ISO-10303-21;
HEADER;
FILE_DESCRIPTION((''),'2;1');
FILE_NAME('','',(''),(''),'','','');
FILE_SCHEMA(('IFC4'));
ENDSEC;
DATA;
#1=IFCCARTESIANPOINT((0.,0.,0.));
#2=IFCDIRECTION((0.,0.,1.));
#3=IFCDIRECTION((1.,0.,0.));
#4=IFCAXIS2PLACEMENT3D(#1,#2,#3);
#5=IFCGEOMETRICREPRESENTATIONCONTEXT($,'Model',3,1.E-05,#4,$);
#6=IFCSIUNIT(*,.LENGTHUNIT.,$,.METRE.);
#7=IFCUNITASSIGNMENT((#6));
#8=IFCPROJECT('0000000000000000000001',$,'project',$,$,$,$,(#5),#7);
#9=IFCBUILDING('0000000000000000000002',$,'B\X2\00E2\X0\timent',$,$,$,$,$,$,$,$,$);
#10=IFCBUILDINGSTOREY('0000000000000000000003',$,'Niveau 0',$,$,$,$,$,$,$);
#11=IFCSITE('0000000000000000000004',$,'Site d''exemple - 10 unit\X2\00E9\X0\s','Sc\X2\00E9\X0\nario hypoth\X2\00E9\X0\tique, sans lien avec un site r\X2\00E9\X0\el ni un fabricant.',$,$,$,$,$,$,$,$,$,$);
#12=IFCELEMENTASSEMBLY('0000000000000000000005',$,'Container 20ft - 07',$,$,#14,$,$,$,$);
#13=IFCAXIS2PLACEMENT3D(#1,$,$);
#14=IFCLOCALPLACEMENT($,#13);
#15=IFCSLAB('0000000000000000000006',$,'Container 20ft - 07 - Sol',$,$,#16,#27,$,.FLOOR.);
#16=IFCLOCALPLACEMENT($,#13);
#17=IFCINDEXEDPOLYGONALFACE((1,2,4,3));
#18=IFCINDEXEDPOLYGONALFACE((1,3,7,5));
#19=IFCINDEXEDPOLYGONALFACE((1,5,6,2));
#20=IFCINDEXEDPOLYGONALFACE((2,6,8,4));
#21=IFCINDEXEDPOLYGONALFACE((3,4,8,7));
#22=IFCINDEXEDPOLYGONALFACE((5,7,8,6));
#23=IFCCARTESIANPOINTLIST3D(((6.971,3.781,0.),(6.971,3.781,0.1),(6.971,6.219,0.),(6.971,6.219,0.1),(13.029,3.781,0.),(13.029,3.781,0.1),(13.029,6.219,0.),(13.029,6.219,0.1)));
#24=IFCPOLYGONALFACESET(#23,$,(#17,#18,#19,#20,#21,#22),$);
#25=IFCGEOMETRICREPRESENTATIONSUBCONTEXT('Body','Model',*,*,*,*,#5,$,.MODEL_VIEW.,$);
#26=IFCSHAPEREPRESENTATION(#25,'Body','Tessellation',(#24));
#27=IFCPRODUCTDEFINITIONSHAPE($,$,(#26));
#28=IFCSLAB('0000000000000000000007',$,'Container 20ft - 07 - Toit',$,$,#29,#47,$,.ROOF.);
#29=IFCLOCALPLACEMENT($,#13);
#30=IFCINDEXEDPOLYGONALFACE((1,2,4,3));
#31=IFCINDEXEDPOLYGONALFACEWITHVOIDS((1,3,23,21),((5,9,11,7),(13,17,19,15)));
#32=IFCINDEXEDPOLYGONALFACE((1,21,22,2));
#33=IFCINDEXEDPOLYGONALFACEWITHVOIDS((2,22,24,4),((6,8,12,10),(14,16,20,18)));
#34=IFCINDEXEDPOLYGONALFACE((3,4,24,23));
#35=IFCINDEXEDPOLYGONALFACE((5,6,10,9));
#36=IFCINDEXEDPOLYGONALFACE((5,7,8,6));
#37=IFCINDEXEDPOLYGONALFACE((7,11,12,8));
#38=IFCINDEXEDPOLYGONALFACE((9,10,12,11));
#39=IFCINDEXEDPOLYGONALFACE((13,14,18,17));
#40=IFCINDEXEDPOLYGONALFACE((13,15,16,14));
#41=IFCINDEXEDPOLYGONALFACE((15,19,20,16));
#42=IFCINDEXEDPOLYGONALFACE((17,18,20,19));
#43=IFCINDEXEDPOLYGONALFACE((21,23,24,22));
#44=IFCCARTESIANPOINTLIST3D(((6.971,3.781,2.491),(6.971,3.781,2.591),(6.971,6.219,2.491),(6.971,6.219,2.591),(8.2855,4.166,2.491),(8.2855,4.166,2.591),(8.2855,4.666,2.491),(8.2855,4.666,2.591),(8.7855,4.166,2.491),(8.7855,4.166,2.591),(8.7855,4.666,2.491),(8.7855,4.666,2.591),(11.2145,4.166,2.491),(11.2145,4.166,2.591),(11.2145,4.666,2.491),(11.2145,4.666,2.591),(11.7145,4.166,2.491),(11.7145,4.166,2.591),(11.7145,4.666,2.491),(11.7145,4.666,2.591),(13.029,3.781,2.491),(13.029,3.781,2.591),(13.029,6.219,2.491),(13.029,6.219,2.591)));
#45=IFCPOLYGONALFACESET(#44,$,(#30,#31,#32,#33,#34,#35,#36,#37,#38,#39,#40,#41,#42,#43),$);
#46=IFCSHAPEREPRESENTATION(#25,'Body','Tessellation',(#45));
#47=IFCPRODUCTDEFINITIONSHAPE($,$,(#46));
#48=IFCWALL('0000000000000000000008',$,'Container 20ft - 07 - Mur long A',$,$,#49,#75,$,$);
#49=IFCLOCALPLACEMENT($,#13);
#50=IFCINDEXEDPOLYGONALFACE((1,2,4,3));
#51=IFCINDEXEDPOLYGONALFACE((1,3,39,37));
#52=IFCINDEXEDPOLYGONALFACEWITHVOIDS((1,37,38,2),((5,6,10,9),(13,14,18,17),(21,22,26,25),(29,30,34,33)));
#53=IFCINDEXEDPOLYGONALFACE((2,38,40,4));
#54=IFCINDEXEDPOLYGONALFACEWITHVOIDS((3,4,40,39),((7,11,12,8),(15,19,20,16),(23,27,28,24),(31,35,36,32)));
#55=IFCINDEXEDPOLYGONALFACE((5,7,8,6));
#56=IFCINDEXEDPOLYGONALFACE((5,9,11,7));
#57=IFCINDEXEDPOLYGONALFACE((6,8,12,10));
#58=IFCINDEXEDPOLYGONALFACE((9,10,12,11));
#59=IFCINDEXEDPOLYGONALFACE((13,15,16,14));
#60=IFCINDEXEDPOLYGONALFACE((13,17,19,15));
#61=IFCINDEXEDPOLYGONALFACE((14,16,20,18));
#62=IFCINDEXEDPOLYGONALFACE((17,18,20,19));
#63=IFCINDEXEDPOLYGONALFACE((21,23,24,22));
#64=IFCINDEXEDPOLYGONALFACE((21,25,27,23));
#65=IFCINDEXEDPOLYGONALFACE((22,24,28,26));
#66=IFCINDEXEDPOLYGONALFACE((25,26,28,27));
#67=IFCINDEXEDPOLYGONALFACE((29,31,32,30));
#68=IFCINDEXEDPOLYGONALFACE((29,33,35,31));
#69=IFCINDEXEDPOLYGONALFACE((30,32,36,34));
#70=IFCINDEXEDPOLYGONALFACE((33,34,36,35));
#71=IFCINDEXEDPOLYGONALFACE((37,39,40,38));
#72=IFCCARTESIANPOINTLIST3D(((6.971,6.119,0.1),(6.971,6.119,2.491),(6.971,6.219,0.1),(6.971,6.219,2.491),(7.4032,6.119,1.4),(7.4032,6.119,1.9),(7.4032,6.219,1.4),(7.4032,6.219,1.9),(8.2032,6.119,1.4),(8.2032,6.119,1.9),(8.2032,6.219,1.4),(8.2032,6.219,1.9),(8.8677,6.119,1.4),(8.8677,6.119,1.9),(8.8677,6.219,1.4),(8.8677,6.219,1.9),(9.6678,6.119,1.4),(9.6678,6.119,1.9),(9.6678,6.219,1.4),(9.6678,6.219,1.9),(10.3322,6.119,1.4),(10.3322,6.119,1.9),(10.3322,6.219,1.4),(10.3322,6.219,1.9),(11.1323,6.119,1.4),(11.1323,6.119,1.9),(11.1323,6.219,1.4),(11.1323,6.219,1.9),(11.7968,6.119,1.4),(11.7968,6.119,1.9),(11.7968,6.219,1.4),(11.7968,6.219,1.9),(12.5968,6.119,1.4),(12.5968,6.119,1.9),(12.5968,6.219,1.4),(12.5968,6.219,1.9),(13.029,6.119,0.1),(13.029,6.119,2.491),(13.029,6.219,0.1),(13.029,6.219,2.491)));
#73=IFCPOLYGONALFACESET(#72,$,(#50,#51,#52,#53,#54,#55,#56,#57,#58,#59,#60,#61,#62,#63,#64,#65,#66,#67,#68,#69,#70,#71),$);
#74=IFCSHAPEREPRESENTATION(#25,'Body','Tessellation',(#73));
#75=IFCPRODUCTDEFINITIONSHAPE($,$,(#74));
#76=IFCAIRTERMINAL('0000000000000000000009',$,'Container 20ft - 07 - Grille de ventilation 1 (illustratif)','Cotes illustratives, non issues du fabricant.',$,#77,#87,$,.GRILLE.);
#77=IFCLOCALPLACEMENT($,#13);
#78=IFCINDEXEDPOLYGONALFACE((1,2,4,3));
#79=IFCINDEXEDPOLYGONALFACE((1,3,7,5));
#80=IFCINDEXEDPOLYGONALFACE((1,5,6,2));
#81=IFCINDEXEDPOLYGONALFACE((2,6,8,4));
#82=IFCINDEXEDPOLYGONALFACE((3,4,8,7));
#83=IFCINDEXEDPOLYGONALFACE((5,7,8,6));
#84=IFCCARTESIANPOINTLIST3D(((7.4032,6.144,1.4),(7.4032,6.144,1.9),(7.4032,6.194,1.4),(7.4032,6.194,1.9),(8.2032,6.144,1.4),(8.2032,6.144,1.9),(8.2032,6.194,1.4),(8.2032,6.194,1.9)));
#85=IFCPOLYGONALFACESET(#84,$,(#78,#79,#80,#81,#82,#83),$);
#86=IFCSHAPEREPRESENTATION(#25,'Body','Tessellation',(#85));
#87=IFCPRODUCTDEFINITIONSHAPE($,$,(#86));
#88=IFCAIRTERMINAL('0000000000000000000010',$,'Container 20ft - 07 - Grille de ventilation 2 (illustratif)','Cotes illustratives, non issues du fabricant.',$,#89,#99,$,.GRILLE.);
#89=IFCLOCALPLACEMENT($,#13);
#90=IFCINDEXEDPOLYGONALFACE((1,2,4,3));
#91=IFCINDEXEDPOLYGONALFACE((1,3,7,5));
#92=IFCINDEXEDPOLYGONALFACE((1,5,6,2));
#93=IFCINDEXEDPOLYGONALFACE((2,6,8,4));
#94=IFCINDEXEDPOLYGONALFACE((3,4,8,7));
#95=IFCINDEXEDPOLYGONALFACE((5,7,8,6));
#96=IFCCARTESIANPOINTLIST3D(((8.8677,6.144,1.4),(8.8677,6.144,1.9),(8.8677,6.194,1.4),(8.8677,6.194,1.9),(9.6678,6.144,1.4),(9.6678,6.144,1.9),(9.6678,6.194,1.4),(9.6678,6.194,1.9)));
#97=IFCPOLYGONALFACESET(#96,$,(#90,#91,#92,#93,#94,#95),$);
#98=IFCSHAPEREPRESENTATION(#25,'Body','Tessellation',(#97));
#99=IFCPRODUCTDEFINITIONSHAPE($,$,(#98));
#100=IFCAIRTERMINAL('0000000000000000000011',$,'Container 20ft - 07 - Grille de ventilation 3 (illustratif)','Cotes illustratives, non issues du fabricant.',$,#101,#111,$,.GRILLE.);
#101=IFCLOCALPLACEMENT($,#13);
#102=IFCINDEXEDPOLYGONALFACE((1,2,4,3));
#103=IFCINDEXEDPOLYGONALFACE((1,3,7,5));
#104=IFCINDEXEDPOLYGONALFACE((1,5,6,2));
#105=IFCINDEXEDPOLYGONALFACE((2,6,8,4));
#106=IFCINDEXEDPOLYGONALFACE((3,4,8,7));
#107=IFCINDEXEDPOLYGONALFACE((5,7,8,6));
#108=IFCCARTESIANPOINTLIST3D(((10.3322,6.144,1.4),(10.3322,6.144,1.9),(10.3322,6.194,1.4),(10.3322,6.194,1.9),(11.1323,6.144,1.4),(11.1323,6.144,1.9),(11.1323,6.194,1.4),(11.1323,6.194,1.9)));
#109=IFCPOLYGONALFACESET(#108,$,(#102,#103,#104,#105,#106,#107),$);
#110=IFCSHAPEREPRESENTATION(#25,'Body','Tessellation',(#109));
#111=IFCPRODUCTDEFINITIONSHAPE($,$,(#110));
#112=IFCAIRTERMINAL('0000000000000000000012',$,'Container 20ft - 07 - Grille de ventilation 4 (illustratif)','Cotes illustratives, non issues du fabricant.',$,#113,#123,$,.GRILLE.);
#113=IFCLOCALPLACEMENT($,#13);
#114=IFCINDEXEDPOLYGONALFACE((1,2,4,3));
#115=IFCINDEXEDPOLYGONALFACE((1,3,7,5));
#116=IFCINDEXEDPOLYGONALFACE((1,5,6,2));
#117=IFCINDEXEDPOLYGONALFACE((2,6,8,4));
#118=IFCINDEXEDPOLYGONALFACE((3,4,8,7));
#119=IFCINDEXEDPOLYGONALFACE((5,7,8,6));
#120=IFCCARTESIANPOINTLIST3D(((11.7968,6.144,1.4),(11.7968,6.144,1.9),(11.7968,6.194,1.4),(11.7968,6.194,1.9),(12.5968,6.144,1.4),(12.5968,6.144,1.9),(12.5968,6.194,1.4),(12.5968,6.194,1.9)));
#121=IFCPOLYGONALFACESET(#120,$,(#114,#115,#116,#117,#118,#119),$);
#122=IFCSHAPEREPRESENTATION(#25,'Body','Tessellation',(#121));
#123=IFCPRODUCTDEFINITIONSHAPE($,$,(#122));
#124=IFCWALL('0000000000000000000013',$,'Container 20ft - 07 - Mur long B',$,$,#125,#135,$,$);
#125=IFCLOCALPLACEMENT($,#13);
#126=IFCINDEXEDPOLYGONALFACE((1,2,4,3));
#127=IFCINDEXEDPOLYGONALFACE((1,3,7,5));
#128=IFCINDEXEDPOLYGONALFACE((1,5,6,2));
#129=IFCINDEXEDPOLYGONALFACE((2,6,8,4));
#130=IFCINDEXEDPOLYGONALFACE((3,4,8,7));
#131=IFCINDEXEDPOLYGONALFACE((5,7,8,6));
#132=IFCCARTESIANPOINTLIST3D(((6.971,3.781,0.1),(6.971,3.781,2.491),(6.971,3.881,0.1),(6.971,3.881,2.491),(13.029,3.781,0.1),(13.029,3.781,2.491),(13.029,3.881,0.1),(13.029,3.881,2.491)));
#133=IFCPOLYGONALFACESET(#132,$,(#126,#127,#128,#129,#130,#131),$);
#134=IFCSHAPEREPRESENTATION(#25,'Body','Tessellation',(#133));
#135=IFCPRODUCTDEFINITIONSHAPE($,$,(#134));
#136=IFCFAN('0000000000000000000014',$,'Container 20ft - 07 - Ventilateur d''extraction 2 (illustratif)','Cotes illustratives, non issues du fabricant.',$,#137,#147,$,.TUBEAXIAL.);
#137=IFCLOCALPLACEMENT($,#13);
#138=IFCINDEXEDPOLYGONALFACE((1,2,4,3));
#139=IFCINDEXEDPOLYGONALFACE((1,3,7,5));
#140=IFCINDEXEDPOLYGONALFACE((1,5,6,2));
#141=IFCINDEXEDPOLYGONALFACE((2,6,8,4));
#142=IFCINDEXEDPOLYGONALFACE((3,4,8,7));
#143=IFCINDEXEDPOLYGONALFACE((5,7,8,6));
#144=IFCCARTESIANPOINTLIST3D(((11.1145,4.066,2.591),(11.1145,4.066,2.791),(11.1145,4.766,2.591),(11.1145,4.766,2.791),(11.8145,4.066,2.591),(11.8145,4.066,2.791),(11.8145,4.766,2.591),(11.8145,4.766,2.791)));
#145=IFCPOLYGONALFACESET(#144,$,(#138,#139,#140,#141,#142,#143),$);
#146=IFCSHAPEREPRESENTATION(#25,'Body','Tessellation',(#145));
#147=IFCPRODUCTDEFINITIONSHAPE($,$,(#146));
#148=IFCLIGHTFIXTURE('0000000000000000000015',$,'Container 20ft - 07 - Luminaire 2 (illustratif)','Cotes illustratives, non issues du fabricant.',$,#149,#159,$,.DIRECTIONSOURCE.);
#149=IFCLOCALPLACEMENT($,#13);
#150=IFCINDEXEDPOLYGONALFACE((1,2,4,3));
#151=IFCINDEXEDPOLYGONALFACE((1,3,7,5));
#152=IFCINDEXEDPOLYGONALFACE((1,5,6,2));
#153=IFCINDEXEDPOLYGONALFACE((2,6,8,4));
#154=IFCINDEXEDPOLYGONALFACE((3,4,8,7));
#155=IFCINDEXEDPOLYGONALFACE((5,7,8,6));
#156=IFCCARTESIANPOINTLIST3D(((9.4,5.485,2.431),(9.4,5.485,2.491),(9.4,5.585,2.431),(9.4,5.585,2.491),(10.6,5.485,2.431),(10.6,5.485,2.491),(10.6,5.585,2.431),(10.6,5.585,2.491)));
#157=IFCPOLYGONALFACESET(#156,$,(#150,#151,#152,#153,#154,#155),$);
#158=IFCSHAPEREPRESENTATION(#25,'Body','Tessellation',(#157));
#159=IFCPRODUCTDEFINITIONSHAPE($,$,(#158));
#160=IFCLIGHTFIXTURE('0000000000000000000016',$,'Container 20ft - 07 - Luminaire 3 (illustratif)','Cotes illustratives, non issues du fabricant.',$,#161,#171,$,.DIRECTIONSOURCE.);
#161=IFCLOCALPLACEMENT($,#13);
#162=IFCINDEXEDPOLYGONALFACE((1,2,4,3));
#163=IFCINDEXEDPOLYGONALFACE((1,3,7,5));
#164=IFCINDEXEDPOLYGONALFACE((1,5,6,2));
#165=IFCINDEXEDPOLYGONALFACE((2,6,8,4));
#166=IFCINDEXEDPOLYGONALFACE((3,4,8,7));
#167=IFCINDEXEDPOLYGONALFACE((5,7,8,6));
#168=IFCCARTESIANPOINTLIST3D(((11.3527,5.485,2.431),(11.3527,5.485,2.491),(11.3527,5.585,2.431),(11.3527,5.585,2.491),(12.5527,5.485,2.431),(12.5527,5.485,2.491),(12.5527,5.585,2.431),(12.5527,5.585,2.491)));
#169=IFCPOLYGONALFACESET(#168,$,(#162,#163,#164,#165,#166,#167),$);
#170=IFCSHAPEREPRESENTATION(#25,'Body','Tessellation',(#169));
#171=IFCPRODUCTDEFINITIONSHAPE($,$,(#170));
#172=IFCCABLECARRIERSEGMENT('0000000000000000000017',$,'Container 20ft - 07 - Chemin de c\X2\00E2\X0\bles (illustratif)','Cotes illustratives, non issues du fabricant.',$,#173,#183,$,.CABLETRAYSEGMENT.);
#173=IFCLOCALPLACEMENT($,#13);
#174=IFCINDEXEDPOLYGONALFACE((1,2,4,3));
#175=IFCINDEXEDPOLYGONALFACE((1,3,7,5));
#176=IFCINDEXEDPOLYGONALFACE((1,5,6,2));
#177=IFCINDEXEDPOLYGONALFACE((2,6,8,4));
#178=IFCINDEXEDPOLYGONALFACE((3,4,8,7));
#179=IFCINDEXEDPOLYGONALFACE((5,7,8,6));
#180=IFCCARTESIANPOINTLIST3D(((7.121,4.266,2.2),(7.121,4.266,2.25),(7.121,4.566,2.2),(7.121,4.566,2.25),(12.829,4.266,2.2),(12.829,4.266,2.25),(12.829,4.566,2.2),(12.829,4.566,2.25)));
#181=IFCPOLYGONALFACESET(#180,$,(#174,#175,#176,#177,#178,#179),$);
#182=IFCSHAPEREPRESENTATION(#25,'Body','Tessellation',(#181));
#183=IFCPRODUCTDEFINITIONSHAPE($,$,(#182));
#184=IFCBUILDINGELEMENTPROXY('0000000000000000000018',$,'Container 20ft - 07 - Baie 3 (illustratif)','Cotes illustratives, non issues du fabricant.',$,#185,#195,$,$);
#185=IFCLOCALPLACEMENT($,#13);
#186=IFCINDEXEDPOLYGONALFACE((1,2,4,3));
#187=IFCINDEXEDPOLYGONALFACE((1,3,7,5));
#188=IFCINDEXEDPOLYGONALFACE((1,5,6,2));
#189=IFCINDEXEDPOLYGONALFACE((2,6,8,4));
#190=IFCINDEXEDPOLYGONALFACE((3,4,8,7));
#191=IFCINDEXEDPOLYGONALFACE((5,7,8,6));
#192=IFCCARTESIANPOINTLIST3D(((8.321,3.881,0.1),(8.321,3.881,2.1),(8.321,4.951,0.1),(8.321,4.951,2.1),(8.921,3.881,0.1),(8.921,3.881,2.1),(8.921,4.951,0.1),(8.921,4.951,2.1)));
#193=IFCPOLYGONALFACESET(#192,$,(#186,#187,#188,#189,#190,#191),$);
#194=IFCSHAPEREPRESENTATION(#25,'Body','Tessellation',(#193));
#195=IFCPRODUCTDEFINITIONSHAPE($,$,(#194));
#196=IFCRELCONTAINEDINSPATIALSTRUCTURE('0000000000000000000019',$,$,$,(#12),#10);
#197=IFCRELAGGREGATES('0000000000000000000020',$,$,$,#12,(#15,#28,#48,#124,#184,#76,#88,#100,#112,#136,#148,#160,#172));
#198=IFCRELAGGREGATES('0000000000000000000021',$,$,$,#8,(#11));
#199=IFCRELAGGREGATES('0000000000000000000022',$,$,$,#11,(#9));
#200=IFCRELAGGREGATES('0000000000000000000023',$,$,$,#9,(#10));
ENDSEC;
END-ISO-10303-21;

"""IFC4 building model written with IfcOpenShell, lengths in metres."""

from ifc_helpers import new_model, si_unit, frame, origin_with_axes, place, context, subcontext, project, spatial, rectangle, extrude, element, fill, aggregate, save


model = new_model("IFC4")

# Units and contexts
model_context = context("Model", 3, precision=1e-05, world=origin_with_axes())
body_context = subcontext(model_context, "Body", "Model", "MODEL_VIEW")
ifc_project = project(units=[si_unit("LENGTHUNIT", "METRE")], contexts=[model_context])

# Site, building, storey
site = spatial("IfcSite", under=ifc_project, Name="Site d'exemple - 10 unités", Description="Scénario hypothétique, sans lien avec un site réel ni un fabricant.")
building = spatial("IfcBuilding", under=site, Name="Bâtiment")
storey = spatial("IfcBuildingStorey", under=building, Name="Niveau 0")

# Element assembly, slabs, openings, walls, air terminals, fan, light fixtures, cable carrier segment, building element proxy
assembly = element("IfcElementAssembly", 1, inside=storey, Name="Container 20ft - 07")
slab_1_placement = place(None, frame((10.0, 5.0, 0.0), z_axis=(0.0, 0.0, 1.0), x_axis=(1.0, 0.0, 0.0)))
slab_1 = element("IfcSlab", 2, at=slab_1_placement, Name="Container 20ft - 07 - Sol", PredefinedType="FLOOR", context=body_context, shape_type="SweptSolid", body=[
    extrude(rectangle(XDim=6.058, YDim=2.438), origin_with_axes(), (0.0, 0.0, 1.0), 0.1),
])
slab_2_placement = place(None, frame((10.0, 5.0, 2.491), z_axis=(0.0, 0.0, 1.0), x_axis=(1.0, 0.0, 0.0)))
slab_2 = element("IfcSlab", 3, at=slab_2_placement, Name="Container 20ft - 07 - Toit", PredefinedType="ROOF", context=body_context, shape_type="SweptSolid", body=[
    extrude(rectangle(XDim=6.058, YDim=2.438), origin_with_axes(), (0.0, 0.0, 1.0), 0.1),
])
opening_1_placement = place(None, frame((8.5355, 4.416, 2.441), z_axis=(0.0, 0.0, 1.0), x_axis=(1.0, 0.0, 0.0)))
element("IfcOpeningElement", 4, at=opening_1_placement, cuts=slab_2, PredefinedType="OPENING", context=body_context, shape_type="SweptSolid", body=[
    extrude(rectangle(XDim=0.5, YDim=0.5), origin_with_axes(), (0.0, 0.0, 1.0), 0.2),
])
opening_2_placement = place(None, frame((11.4645, 4.416, 2.441), z_axis=(0.0, 0.0, 1.0), x_axis=(1.0, 0.0, 0.0)))
element("IfcOpeningElement", 5, at=opening_2_placement, cuts=slab_2, PredefinedType="OPENING", context=body_context, shape_type="SweptSolid", body=[
    extrude(rectangle(XDim=0.5, YDim=0.5), origin_with_axes(), (0.0, 0.0, 1.0), 0.2),
])
wall_1_placement = place(None, frame((10.0, 6.169, 0.1), z_axis=(0.0, 0.0, 1.0), x_axis=(1.0, 0.0, 0.0)))
wall_1 = element("IfcWall", 6, at=wall_1_placement, Name="Container 20ft - 07 - Mur long A", context=body_context, shape_type="SweptSolid", body=[
    extrude(rectangle(XDim=6.058, YDim=0.1), origin_with_axes(), (0.0, 0.0, 1.0), 2.391),
])
opening_3_placement = place(None, frame((7.8033, 6.169, 1.4), z_axis=(0.0, 0.0, 1.0), x_axis=(1.0, 0.0, 0.0)))
opening_3 = element("IfcOpeningElement", 7, at=opening_3_placement, cuts=wall_1, PredefinedType="OPENING", context=body_context, shape_type="SweptSolid", body=[
    extrude(rectangle(XDim=0.8, YDim=0.2), origin_with_axes(), (0.0, 0.0, 1.0), 0.5),
])
opening_4_placement = place(None, frame((9.2677, 6.169, 1.4), z_axis=(0.0, 0.0, 1.0), x_axis=(1.0, 0.0, 0.0)))
opening_4 = element("IfcOpeningElement", 8, at=opening_4_placement, cuts=wall_1, PredefinedType="OPENING", context=body_context, shape_type="SweptSolid", body=[
    extrude(rectangle(XDim=0.8, YDim=0.2), origin_with_axes(), (0.0, 0.0, 1.0), 0.5),
])
opening_5_placement = place(None, frame((10.7323, 6.169, 1.4), z_axis=(0.0, 0.0, 1.0), x_axis=(1.0, 0.0, 0.0)))
opening_5 = element("IfcOpeningElement", 9, at=opening_5_placement, cuts=wall_1, PredefinedType="OPENING", context=body_context, shape_type="SweptSolid", body=[
    extrude(rectangle(XDim=0.8, YDim=0.2), origin_with_axes(), (0.0, 0.0, 1.0), 0.5),
])
opening_6_placement = place(None, frame((12.1967, 6.169, 1.4), z_axis=(0.0, 0.0, 1.0), x_axis=(1.0, 0.0, 0.0)))
opening_6 = element("IfcOpeningElement", 10, at=opening_6_placement, cuts=wall_1, PredefinedType="OPENING", context=body_context, shape_type="SweptSolid", body=[
    extrude(rectangle(XDim=0.8, YDim=0.2), origin_with_axes(), (0.0, 0.0, 1.0), 0.5),
])
air_terminal_1_placement = place(None, frame((7.8033, 6.169, 1.4), z_axis=(0.0, 0.0, 1.0), x_axis=(1.0, 0.0, 0.0)))
air_terminal_1 = element("IfcAirTerminal", 11, at=air_terminal_1_placement, Name="Container 20ft - 07 - Grille de ventilation 1 (illustratif)", Description="Cotes illustratives, non issues du fabricant.", PredefinedType="GRILLE", context=body_context, shape_type="SweptSolid", body=[
    extrude(rectangle(XDim=0.8, YDim=0.05), origin_with_axes(), (0.0, 0.0, 1.0), 0.5),
])
fill(opening_3, air_terminal_1)
air_terminal_2_placement = place(None, frame((9.2677, 6.169, 1.4), z_axis=(0.0, 0.0, 1.0), x_axis=(1.0, 0.0, 0.0)))
air_terminal_2 = element("IfcAirTerminal", 12, at=air_terminal_2_placement, Name="Container 20ft - 07 - Grille de ventilation 2 (illustratif)", Description="Cotes illustratives, non issues du fabricant.", PredefinedType="GRILLE", context=body_context, shape_type="SweptSolid", body=[
    extrude(rectangle(XDim=0.8, YDim=0.05), origin_with_axes(), (0.0, 0.0, 1.0), 0.5),
])
fill(opening_4, air_terminal_2)
air_terminal_3_placement = place(None, frame((10.7323, 6.169, 1.4), z_axis=(0.0, 0.0, 1.0), x_axis=(1.0, 0.0, 0.0)))
air_terminal_3 = element("IfcAirTerminal", 13, at=air_terminal_3_placement, Name="Container 20ft - 07 - Grille de ventilation 3 (illustratif)", Description="Cotes illustratives, non issues du fabricant.", PredefinedType="GRILLE", context=body_context, shape_type="SweptSolid", body=[
    extrude(rectangle(XDim=0.8, YDim=0.05), origin_with_axes(), (0.0, 0.0, 1.0), 0.5),
])
fill(opening_5, air_terminal_3)
air_terminal_4_placement = place(None, frame((12.1967, 6.169, 1.4), z_axis=(0.0, 0.0, 1.0), x_axis=(1.0, 0.0, 0.0)))
air_terminal_4 = element("IfcAirTerminal", 14, at=air_terminal_4_placement, Name="Container 20ft - 07 - Grille de ventilation 4 (illustratif)", Description="Cotes illustratives, non issues du fabricant.", PredefinedType="GRILLE", context=body_context, shape_type="SweptSolid", body=[
    extrude(rectangle(XDim=0.8, YDim=0.05), origin_with_axes(), (0.0, 0.0, 1.0), 0.5),
])
fill(opening_6, air_terminal_4)
wall_2_placement = place(None, frame((10.0, 3.831, 0.1), z_axis=(0.0, 0.0, 1.0), x_axis=(1.0, 0.0, 0.0)))
wall_2 = element("IfcWall", 15, at=wall_2_placement, Name="Container 20ft - 07 - Mur long B", context=body_context, shape_type="SweptSolid", body=[
    extrude(rectangle(XDim=6.058, YDim=0.1), origin_with_axes(), (0.0, 0.0, 1.0), 2.391),
])
fan_placement = place(None, frame((11.4645, 4.416, 2.591), z_axis=(0.0, 0.0, 1.0), x_axis=(1.0, 0.0, 0.0)))
fan = element("IfcFan", 16, at=fan_placement, Name="Container 20ft - 07 - Ventilateur d'extraction 2 (illustratif)", Description="Cotes illustratives, non issues du fabricant.", PredefinedType="TUBEAXIAL", context=body_context, shape_type="SweptSolid", body=[
    extrude(rectangle(XDim=0.7, YDim=0.7), origin_with_axes(), (0.0, 0.0, 1.0), 0.2),
])
light_fixture_1_placement = place(None, frame((10.0, 5.535, 2.431), z_axis=(0.0, 0.0, 1.0), x_axis=(1.0, 0.0, 0.0)))
light_fixture_1 = element("IfcLightFixture", 17, at=light_fixture_1_placement, Name="Container 20ft - 07 - Luminaire 2 (illustratif)", Description="Cotes illustratives, non issues du fabricant.", PredefinedType="DIRECTIONSOURCE", context=body_context, shape_type="SweptSolid", body=[
    extrude(rectangle(XDim=1.2, YDim=0.1), origin_with_axes(), (0.0, 0.0, 1.0), 0.06),
])
light_fixture_2_placement = place(None, frame((11.9527, 5.535, 2.431), z_axis=(0.0, 0.0, 1.0), x_axis=(1.0, 0.0, 0.0)))
light_fixture_2 = element("IfcLightFixture", 18, at=light_fixture_2_placement, Name="Container 20ft - 07 - Luminaire 3 (illustratif)", Description="Cotes illustratives, non issues du fabricant.", PredefinedType="DIRECTIONSOURCE", context=body_context, shape_type="SweptSolid", body=[
    extrude(rectangle(XDim=1.2, YDim=0.1), origin_with_axes(), (0.0, 0.0, 1.0), 0.06),
])
cable_carrier_segment_placement = place(None, frame((9.975, 4.416, 2.2), z_axis=(0.0, 0.0, 1.0), x_axis=(1.0, 0.0, 0.0)))
cable_carrier_segment = element("IfcCableCarrierSegment", 19, at=cable_carrier_segment_placement, Name="Container 20ft - 07 - Chemin de câbles (illustratif)", Description="Cotes illustratives, non issues du fabricant.", PredefinedType="CABLETRAYSEGMENT", context=body_context, shape_type="SweptSolid", body=[
    extrude(rectangle(XDim=5.708, YDim=0.3), origin_with_axes(), (0.0, 0.0, 1.0), 0.05),
])
proxy_1_placement = place(None, frame((8.621, 4.416, 0.1), z_axis=(0.0, 0.0, 1.0), x_axis=(1.0, 0.0, 0.0)))
proxy_1 = element("IfcBuildingElementProxy", 20, at=proxy_1_placement, Name="Container 20ft - 07 - Baie 3 (illustratif)", Description="Cotes illustratives, non issues du fabricant.", context=body_context, shape_type="SweptSolid", body=[
    extrude(rectangle(XDim=0.6, YDim=1.07), origin_with_axes(), (0.0, 0.0, 1.0), 2.0),
])
aggregate(assembly, [slab_1, slab_2, wall_1, wall_2, proxy_1, air_terminal_1, air_terminal_2, air_terminal_3, air_terminal_4, fan, light_fixture_1, light_fixture_2, cable_carrier_segment])

save(model, "model.ifc")
